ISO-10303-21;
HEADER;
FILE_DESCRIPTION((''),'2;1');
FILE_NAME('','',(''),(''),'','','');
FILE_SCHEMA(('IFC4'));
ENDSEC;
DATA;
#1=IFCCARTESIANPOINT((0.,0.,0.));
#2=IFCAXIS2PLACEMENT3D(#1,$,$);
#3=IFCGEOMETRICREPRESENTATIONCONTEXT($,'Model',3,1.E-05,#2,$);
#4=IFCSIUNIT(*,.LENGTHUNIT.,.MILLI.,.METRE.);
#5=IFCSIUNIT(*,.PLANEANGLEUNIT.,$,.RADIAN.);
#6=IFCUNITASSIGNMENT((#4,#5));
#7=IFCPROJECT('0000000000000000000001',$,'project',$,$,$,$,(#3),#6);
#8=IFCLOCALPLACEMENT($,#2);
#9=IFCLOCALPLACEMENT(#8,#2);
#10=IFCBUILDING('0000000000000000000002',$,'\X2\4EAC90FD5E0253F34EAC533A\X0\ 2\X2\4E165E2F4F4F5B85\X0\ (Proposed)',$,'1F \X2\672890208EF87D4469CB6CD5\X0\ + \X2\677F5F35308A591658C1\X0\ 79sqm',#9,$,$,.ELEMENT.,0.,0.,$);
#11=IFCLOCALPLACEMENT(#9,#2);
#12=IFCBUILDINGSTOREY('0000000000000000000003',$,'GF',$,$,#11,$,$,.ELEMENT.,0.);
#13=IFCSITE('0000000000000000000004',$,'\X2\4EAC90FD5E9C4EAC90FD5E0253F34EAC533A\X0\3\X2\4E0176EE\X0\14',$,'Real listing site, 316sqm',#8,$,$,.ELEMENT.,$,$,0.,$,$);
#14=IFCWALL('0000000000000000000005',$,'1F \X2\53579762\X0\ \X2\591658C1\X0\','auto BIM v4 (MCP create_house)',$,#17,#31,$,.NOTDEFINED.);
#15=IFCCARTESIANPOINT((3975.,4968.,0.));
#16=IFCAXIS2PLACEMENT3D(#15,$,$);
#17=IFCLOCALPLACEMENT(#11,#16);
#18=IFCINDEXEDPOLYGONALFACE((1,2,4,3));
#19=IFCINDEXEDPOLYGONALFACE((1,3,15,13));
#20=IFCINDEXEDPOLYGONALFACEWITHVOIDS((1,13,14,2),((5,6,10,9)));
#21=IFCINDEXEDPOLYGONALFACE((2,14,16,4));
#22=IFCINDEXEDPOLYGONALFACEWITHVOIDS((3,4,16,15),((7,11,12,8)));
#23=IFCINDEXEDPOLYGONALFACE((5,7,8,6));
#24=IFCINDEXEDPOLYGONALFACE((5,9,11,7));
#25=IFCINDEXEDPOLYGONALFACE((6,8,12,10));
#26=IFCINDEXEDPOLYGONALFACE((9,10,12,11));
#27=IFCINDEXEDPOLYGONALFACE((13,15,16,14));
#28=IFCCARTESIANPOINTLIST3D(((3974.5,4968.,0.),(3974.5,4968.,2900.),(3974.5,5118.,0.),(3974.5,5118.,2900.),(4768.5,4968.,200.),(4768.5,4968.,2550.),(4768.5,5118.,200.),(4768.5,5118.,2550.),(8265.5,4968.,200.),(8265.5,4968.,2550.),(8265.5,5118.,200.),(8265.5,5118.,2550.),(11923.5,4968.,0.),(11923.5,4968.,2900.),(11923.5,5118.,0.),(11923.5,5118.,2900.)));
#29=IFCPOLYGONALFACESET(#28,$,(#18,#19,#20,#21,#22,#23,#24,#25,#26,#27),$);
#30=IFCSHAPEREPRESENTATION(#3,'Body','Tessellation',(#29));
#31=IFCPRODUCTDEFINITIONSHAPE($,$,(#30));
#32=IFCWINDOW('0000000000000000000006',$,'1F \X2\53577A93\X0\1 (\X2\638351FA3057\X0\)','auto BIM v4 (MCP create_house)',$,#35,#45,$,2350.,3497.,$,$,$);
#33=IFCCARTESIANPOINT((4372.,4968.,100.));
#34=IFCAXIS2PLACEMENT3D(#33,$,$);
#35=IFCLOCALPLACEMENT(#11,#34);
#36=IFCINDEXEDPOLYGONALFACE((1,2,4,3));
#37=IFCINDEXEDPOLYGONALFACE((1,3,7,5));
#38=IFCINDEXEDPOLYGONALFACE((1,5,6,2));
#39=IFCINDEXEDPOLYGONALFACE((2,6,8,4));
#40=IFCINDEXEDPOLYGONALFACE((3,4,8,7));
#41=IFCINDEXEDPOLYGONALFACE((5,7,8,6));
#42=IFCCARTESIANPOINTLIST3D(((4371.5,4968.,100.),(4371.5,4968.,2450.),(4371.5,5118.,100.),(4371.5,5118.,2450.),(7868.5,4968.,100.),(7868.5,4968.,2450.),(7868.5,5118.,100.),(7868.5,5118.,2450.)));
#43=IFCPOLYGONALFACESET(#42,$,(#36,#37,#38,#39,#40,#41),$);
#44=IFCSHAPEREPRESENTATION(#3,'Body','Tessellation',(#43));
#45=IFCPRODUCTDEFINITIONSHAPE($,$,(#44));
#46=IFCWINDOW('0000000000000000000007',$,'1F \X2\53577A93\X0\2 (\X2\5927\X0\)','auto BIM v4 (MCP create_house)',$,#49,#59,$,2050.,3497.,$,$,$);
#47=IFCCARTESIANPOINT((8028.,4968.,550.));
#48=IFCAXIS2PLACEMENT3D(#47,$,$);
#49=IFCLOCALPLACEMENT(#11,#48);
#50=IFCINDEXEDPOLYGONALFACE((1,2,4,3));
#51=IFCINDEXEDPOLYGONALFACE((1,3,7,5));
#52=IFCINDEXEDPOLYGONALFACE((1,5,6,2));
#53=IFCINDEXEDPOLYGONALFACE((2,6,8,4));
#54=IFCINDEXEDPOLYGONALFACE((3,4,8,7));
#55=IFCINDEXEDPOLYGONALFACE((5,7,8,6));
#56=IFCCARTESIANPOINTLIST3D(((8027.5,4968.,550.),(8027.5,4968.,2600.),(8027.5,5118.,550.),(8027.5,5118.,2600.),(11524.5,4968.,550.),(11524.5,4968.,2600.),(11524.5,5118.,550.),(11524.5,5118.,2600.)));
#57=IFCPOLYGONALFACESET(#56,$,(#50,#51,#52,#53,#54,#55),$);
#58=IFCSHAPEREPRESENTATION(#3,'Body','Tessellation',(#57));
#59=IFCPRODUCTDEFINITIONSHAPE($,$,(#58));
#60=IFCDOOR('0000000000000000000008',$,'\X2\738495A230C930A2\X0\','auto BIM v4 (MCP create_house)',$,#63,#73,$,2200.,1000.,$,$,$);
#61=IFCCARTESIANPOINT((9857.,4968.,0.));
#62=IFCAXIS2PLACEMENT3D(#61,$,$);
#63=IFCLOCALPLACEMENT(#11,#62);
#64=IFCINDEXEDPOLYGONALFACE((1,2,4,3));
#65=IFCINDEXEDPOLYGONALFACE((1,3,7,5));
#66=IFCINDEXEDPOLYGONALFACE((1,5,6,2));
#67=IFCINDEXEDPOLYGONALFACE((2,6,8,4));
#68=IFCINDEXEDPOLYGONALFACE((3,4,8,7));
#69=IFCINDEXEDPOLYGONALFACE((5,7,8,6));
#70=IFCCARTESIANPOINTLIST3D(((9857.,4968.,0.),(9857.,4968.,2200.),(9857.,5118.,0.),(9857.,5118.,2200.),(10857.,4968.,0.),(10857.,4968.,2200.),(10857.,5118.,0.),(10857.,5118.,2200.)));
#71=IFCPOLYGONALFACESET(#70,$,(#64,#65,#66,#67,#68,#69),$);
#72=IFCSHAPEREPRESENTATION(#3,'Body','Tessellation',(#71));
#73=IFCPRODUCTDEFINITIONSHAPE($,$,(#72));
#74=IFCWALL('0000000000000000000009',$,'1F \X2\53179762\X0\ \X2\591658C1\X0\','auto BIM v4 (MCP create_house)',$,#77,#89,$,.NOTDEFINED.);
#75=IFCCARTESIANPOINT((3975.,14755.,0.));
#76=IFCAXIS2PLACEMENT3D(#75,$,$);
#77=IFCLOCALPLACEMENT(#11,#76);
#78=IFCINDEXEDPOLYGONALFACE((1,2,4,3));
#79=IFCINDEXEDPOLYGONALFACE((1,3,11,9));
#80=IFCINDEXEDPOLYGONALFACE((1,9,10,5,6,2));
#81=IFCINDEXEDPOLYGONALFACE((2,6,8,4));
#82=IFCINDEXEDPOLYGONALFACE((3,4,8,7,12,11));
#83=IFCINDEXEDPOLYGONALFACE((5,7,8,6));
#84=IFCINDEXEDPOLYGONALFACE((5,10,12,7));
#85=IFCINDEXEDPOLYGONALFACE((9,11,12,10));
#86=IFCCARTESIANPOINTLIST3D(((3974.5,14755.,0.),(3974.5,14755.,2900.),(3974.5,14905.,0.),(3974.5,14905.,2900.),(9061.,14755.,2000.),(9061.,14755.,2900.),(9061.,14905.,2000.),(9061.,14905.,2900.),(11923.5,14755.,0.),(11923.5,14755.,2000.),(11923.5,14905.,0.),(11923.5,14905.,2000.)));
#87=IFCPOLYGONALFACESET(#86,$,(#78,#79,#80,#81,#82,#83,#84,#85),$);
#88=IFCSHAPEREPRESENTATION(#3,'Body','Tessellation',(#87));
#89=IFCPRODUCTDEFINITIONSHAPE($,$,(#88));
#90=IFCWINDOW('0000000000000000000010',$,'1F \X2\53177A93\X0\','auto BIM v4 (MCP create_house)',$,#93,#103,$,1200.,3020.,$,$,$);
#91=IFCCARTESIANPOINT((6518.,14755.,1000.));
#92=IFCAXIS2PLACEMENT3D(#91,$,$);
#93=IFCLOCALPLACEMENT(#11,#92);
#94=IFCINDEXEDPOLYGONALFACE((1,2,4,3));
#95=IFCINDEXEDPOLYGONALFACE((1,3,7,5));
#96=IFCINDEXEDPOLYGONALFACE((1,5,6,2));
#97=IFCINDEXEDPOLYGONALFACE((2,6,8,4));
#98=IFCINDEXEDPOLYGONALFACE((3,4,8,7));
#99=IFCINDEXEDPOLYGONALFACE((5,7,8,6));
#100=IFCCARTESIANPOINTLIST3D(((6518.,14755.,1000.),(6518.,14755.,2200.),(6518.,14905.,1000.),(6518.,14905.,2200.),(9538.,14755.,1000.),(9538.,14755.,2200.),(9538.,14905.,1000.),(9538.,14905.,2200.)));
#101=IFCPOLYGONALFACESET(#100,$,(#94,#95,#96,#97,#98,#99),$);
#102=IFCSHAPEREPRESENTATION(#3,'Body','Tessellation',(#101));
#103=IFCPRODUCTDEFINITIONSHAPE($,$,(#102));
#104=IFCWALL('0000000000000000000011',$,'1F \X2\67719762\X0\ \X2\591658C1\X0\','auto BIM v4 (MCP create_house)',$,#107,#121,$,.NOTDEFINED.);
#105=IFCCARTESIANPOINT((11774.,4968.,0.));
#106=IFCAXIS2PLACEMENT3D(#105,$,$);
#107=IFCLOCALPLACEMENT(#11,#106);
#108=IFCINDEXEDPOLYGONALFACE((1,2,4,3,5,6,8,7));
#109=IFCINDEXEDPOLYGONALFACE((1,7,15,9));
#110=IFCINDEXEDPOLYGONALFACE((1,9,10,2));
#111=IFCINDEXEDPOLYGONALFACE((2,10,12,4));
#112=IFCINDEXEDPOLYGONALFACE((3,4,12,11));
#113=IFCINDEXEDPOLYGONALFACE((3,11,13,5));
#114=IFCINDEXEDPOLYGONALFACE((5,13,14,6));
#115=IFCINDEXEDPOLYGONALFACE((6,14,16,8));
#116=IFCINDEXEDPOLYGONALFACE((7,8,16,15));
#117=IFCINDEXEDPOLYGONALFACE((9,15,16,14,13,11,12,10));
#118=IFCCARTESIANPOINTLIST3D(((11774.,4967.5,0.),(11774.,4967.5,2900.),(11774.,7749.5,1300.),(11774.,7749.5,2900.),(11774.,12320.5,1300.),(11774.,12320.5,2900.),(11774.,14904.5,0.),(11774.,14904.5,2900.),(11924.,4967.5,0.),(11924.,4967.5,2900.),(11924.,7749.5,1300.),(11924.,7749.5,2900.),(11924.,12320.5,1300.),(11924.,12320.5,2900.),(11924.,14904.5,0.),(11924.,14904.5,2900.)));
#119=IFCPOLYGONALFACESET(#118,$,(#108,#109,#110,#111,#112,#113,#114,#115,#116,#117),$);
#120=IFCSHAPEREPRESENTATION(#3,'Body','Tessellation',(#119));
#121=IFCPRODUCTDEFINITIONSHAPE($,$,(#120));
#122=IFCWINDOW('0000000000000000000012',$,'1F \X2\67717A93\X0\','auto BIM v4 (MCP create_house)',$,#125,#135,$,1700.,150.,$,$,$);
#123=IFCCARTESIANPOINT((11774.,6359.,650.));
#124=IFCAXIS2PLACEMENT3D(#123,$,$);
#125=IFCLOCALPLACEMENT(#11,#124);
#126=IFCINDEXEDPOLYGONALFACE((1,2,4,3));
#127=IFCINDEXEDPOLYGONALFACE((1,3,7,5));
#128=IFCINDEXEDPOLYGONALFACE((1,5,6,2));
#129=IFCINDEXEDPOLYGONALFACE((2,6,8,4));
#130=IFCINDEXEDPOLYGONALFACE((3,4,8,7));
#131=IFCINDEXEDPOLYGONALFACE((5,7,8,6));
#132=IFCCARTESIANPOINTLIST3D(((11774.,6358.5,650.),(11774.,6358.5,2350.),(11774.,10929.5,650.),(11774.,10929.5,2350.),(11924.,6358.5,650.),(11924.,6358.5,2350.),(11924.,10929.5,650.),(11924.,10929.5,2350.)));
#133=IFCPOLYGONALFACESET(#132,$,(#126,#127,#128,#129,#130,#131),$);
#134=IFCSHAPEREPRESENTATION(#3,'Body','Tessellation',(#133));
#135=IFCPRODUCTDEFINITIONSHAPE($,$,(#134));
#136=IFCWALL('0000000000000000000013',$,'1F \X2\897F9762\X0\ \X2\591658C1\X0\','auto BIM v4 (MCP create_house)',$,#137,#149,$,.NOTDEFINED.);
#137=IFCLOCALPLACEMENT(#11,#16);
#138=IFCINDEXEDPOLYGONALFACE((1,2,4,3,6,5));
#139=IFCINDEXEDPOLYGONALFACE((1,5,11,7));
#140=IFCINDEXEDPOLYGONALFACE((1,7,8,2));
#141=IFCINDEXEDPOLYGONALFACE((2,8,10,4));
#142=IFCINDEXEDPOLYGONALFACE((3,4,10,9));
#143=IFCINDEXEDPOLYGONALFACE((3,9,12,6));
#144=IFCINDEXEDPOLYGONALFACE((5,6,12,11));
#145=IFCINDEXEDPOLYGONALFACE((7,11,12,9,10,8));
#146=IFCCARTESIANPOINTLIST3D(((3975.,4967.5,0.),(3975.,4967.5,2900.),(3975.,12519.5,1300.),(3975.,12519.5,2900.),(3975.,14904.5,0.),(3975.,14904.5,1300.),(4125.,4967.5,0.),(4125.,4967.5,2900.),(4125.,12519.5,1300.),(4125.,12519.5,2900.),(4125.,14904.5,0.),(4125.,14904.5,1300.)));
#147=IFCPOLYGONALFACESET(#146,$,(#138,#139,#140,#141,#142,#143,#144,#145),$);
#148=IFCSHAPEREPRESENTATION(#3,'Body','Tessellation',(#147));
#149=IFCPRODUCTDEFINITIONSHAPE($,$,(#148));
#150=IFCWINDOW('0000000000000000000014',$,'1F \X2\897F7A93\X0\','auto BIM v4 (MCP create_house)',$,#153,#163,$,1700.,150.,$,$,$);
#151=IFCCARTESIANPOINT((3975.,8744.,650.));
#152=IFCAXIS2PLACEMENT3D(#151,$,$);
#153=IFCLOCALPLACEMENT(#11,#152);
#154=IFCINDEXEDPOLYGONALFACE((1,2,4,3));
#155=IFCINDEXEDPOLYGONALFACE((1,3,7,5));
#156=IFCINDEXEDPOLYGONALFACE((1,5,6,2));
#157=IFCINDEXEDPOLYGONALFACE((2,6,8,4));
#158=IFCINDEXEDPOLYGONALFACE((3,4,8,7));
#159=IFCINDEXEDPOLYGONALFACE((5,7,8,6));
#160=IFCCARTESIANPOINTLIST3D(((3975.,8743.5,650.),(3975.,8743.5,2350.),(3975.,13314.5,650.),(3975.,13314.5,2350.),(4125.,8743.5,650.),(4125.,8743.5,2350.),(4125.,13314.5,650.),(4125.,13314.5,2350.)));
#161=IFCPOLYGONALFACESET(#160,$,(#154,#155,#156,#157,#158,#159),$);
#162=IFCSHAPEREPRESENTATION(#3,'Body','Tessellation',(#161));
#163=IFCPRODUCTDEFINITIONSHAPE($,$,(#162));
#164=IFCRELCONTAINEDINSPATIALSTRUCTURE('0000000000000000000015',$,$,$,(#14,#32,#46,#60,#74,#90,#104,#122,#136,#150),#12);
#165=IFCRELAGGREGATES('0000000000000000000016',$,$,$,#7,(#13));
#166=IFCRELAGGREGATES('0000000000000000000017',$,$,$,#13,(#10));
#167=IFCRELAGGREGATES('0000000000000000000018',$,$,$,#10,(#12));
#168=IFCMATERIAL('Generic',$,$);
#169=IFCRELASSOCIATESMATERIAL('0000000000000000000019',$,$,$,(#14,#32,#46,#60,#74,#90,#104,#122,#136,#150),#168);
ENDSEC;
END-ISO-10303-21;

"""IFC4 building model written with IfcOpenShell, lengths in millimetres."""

from ifc_helpers import new_model, si_unit, frame, frame_2d, origin, place, context, project, spatial, rectangle, extrude, material, element, fill, save


model = new_model("IFC4")

# Units and contexts
model_context = context("Model", 3, precision=1e-05, world=origin())
ifc_project = project(units=[si_unit("LENGTHUNIT", "METRE", prefix="MILLI"), si_unit("PLANEANGLEUNIT", "RADIAN")], contexts=[model_context])

# Site, building, storey
site_placement = place(None, origin())
site = spatial("IfcSite", under=ifc_project, at=site_placement, Name="京都府京都市右京区3丁目14", ObjectType="Real listing site, 316sqm", CompositionType="ELEMENT", RefElevation=0.0)
building_placement = place(site_placement, origin())
building = spatial("IfcBuilding", under=site, at=building_placement, Name="京都市右京区 2世帯住宅 (Proposed)", ObjectType="1F 木造軸組構法 + 板張り外壁 79sqm", CompositionType="ELEMENT", ElevationOfRefHeight=0.0, ElevationOfTerrain=0.0)
storey_placement = place(building_placement, origin())
storey = spatial("IfcBuildingStorey", under=building, at=storey_placement, Name="GF", CompositionType="ELEMENT", Elevation=0.0)

# Shared definitions
ifc_material = material(Name="Generic")

# Wall, openings, windows, door
wall_1_placement = place(storey_placement, frame((3975.0, 4968.0, 0.0)))
wall_1 = element("IfcWall", 1, at=wall_1_placement, inside=storey, material=ifc_material, Name="1F 南面 外壁", Description="auto BIM v4 (MCP create_house)", PredefinedType="NOTDEFINED", context=model_context, shape_type="SweptSolid", body=[
    extrude(rectangle(XDim=7949.0, YDim=150.0, at=frame_2d((3974.0, 75.0))), frame((3975.0, 4968.0, 0.0)), (0.0, 0.0, 1.0), 2900.0),
])
opening_1_placement = place(storey_placement, frame((4372.0, 4968.0, 100.0)))
opening_1 = element("IfcOpeningElement", 2, at=opening_1_placement, cuts=wall_1, PredefinedType="NOTDEFINED", context=model_context, shape_type="SweptSolid", body=[
    extrude(rectangle(XDim=3497.0, YDim=150.0, at=frame_2d((1748.0, 75.0))), frame((4372.0, 4968.0, 100.0)), (0.0, 0.0, 1.0), 2350.0),
])
opening_2_placement = place(storey_placement, frame((8028.0, 4968.0, 550.0)))
opening_2 = element("IfcOpeningElement", 3, at=opening_2_placement, cuts=wall_1, PredefinedType="NOTDEFINED", context=model_context, shape_type="SweptSolid", body=[
    extrude(rectangle(XDim=3497.0, YDim=150.0, at=frame_2d((1748.0, 75.0))), frame((8028.0, 4968.0, 550.0)), (0.0, 0.0, 1.0), 2050.0),
])
opening_3_placement = place(storey_placement, frame((9857.0, 4968.0, 0.0)))
opening_3 = element("IfcOpeningElement", 4, at=opening_3_placement, cuts=wall_1, PredefinedType="NOTDEFINED", context=model_context, shape_type="SweptSolid", body=[
    extrude(rectangle(XDim=1000.0, YDim=150.0, at=frame_2d((500.0, 75.0))), frame((9857.0, 4968.0, 0.0)), (0.0, 0.0, 1.0), 2200.0),
])
window_1_placement = place(storey_placement, frame((4372.0, 4968.0, 100.0)))
window_1 = element("IfcWindow", 5, at=window_1_placement, inside=storey, material=ifc_material, Name="1F 南窓1 (掃出し)", Description="auto BIM v4 (MCP create_house)", OverallHeight=2350.0, OverallWidth=3497.0, context=model_context, shape_type="SweptSolid", body=[
    extrude(rectangle(XDim=3497.0, YDim=150.0, at=frame_2d((1748.0, 75.0))), frame((4372.0, 4968.0, 100.0)), (0.0, 0.0, 1.0), 2350.0),
])
fill(opening_1, window_1)
window_2_placement = place(storey_placement, frame((8028.0, 4968.0, 550.0)))
window_2 = element("IfcWindow", 6, at=window_2_placement, inside=storey, material=ifc_material, Name="1F 南窓2 (大)", Description="auto BIM v4 (MCP create_house)", OverallHeight=2050.0, OverallWidth=3497.0, context=model_context, shape_type="SweptSolid", body=[
    extrude(rectangle(XDim=3497.0, YDim=150.0, at=frame_2d((1748.0, 75.0))), frame((8028.0, 4968.0, 550.0)), (0.0, 0.0, 1.0), 2050.0),
])
fill(opening_2, window_2)
door_placement = place(storey_placement, frame((9857.0, 4968.0, 0.0)))
door = element("IfcDoor", 7, at=door_placement, inside=storey, material=ifc_material, Name="玄関ドア", Description="auto BIM v4 (MCP create_house)", OverallHeight=2200.0, OverallWidth=1000.0, context=model_context, shape_type="SweptSolid", body=[
    extrude(rectangle(XDim=1000.0, YDim=150.0, at=frame_2d((500.0, 75.0))), frame((9857.0, 4968.0, 0.0)), (0.0, 0.0, 1.0), 2200.0),
])
fill(opening_3, door)

# Walls, openings, windows
wall_2_placement = place(storey_placement, frame((3975.0, 14755.0, 0.0)))
wall_2 = element("IfcWall", 8, at=wall_2_placement, inside=storey, material=ifc_material, Name="1F 北面 外壁", Description="auto BIM v4 (MCP create_house)", PredefinedType="NOTDEFINED", context=model_context, shape_type="SweptSolid", body=[
    extrude(rectangle(XDim=7949.0, YDim=150.0, at=frame_2d((3974.0, 75.0))), frame((3975.0, 14755.0, 0.0)), (0.0, 0.0, 1.0), 2900.0),
])
opening_4_placement = place(storey_placement, frame((6518.0, 14755.0, 1000.0)))
opening_4 = element("IfcOpeningElement", 9, at=opening_4_placement, cuts=wall_2, PredefinedType="NOTDEFINED", context=model_context, shape_type="SweptSolid", body=[
    extrude(rectangle(XDim=3020.0, YDim=150.0, at=frame_2d((1510.0, 75.0))), frame((6518.0, 14755.0, 1000.0)), (0.0, 0.0, 1.0), 1200.0),
])
window_3_placement = place(storey_placement, frame((6518.0, 14755.0, 1000.0)))
window_3 = element("IfcWindow", 10, at=window_3_placement, inside=storey, material=ifc_material, Name="1F 北窓", Description="auto BIM v4 (MCP create_house)", OverallHeight=1200.0, OverallWidth=3020.0, context=model_context, shape_type="SweptSolid", body=[
    extrude(rectangle(XDim=3020.0, YDim=150.0, at=frame_2d((1510.0, 75.0))), frame((6518.0, 14755.0, 1000.0)), (0.0, 0.0, 1.0), 1200.0),
])
fill(opening_4, window_3)
wall_3_placement = place(storey_placement, frame((11774.0, 4968.0, 0.0)))
wall_3 = element("IfcWall", 11, at=wall_3_placement, inside=storey, material=ifc_material, Name="1F 東面 外壁", Description="auto BIM v4 (MCP create_house)", PredefinedType="NOTDEFINED", context=model_context, shape_type="SweptSolid", body=[
    extrude(rectangle(XDim=150.0, YDim=9937.0, at=frame_2d((75.0, 4968.0))), frame((11774.0, 4968.0, 0.0)), (0.0, 0.0, 1.0), 2900.0),
])
opening_5_placement = place(storey_placement, frame((11774.0, 6359.0, 650.0)))
opening_5 = element("IfcOpeningElement", 12, at=opening_5_placement, cuts=wall_3, PredefinedType="NOTDEFINED", context=model_context, shape_type="SweptSolid", body=[
    extrude(rectangle(XDim=150.0, YDim=4571.0, at=frame_2d((75.0, 2285.0))), frame((11774.0, 6359.0, 650.0)), (0.0, 0.0, 1.0), 1700.0),
])
window_4_placement = place(storey_placement, frame((11774.0, 6359.0, 650.0)))
window_4 = element("IfcWindow", 13, at=window_4_placement, inside=storey, material=ifc_material, Name="1F 東窓", Description="auto BIM v4 (MCP create_house)", OverallHeight=1700.0, OverallWidth=150.0, context=model_context, shape_type="SweptSolid", body=[
    extrude(rectangle(XDim=150.0, YDim=4571.0, at=frame_2d((75.0, 2285.0))), frame((11774.0, 6359.0, 650.0)), (0.0, 0.0, 1.0), 1700.0),
])
fill(opening_5, window_4)
wall_4_placement = place(storey_placement, frame((3975.0, 4968.0, 0.0)))
wall_4 = element("IfcWall", 14, at=wall_4_placement, inside=storey, material=ifc_material, Name="1F 西面 外壁", Description="auto BIM v4 (MCP create_house)", PredefinedType="NOTDEFINED", context=model_context, shape_type="SweptSolid", body=[
    extrude(rectangle(XDim=150.0, YDim=9937.0, at=frame_2d((75.0, 4968.0))), frame((3975.0, 4968.0, 0.0)), (0.0, 0.0, 1.0), 2900.0),
])
opening_6_placement = place(storey_placement, frame((3975.0, 8744.0, 650.0)))
opening_6 = element("IfcOpeningElement", 15, at=opening_6_placement, cuts=wall_4, PredefinedType="NOTDEFINED", context=model_context, shape_type="SweptSolid", body=[
    extrude(rectangle(XDim=150.0, YDim=4571.0, at=frame_2d((75.0, 2285.0))), frame((3975.0, 8744.0, 650.0)), (0.0, 0.0, 1.0), 1700.0),
])
window_5_placement = place(storey_placement, frame((3975.0, 8744.0, 650.0)))
window_5 = element("IfcWindow", 16, at=window_5_placement, inside=storey, material=ifc_material, Name="1F 西窓", Description="auto BIM v4 (MCP create_house)", OverallHeight=1700.0, OverallWidth=150.0, context=model_context, shape_type="SweptSolid", body=[
    extrude(rectangle(XDim=150.0, YDim=4571.0, at=frame_2d((75.0, 2285.0))), frame((3975.0, 8744.0, 650.0)), (0.0, 0.0, 1.0), 1700.0),
])
fill(opening_6, window_5)

save(model, "model.ifc")
